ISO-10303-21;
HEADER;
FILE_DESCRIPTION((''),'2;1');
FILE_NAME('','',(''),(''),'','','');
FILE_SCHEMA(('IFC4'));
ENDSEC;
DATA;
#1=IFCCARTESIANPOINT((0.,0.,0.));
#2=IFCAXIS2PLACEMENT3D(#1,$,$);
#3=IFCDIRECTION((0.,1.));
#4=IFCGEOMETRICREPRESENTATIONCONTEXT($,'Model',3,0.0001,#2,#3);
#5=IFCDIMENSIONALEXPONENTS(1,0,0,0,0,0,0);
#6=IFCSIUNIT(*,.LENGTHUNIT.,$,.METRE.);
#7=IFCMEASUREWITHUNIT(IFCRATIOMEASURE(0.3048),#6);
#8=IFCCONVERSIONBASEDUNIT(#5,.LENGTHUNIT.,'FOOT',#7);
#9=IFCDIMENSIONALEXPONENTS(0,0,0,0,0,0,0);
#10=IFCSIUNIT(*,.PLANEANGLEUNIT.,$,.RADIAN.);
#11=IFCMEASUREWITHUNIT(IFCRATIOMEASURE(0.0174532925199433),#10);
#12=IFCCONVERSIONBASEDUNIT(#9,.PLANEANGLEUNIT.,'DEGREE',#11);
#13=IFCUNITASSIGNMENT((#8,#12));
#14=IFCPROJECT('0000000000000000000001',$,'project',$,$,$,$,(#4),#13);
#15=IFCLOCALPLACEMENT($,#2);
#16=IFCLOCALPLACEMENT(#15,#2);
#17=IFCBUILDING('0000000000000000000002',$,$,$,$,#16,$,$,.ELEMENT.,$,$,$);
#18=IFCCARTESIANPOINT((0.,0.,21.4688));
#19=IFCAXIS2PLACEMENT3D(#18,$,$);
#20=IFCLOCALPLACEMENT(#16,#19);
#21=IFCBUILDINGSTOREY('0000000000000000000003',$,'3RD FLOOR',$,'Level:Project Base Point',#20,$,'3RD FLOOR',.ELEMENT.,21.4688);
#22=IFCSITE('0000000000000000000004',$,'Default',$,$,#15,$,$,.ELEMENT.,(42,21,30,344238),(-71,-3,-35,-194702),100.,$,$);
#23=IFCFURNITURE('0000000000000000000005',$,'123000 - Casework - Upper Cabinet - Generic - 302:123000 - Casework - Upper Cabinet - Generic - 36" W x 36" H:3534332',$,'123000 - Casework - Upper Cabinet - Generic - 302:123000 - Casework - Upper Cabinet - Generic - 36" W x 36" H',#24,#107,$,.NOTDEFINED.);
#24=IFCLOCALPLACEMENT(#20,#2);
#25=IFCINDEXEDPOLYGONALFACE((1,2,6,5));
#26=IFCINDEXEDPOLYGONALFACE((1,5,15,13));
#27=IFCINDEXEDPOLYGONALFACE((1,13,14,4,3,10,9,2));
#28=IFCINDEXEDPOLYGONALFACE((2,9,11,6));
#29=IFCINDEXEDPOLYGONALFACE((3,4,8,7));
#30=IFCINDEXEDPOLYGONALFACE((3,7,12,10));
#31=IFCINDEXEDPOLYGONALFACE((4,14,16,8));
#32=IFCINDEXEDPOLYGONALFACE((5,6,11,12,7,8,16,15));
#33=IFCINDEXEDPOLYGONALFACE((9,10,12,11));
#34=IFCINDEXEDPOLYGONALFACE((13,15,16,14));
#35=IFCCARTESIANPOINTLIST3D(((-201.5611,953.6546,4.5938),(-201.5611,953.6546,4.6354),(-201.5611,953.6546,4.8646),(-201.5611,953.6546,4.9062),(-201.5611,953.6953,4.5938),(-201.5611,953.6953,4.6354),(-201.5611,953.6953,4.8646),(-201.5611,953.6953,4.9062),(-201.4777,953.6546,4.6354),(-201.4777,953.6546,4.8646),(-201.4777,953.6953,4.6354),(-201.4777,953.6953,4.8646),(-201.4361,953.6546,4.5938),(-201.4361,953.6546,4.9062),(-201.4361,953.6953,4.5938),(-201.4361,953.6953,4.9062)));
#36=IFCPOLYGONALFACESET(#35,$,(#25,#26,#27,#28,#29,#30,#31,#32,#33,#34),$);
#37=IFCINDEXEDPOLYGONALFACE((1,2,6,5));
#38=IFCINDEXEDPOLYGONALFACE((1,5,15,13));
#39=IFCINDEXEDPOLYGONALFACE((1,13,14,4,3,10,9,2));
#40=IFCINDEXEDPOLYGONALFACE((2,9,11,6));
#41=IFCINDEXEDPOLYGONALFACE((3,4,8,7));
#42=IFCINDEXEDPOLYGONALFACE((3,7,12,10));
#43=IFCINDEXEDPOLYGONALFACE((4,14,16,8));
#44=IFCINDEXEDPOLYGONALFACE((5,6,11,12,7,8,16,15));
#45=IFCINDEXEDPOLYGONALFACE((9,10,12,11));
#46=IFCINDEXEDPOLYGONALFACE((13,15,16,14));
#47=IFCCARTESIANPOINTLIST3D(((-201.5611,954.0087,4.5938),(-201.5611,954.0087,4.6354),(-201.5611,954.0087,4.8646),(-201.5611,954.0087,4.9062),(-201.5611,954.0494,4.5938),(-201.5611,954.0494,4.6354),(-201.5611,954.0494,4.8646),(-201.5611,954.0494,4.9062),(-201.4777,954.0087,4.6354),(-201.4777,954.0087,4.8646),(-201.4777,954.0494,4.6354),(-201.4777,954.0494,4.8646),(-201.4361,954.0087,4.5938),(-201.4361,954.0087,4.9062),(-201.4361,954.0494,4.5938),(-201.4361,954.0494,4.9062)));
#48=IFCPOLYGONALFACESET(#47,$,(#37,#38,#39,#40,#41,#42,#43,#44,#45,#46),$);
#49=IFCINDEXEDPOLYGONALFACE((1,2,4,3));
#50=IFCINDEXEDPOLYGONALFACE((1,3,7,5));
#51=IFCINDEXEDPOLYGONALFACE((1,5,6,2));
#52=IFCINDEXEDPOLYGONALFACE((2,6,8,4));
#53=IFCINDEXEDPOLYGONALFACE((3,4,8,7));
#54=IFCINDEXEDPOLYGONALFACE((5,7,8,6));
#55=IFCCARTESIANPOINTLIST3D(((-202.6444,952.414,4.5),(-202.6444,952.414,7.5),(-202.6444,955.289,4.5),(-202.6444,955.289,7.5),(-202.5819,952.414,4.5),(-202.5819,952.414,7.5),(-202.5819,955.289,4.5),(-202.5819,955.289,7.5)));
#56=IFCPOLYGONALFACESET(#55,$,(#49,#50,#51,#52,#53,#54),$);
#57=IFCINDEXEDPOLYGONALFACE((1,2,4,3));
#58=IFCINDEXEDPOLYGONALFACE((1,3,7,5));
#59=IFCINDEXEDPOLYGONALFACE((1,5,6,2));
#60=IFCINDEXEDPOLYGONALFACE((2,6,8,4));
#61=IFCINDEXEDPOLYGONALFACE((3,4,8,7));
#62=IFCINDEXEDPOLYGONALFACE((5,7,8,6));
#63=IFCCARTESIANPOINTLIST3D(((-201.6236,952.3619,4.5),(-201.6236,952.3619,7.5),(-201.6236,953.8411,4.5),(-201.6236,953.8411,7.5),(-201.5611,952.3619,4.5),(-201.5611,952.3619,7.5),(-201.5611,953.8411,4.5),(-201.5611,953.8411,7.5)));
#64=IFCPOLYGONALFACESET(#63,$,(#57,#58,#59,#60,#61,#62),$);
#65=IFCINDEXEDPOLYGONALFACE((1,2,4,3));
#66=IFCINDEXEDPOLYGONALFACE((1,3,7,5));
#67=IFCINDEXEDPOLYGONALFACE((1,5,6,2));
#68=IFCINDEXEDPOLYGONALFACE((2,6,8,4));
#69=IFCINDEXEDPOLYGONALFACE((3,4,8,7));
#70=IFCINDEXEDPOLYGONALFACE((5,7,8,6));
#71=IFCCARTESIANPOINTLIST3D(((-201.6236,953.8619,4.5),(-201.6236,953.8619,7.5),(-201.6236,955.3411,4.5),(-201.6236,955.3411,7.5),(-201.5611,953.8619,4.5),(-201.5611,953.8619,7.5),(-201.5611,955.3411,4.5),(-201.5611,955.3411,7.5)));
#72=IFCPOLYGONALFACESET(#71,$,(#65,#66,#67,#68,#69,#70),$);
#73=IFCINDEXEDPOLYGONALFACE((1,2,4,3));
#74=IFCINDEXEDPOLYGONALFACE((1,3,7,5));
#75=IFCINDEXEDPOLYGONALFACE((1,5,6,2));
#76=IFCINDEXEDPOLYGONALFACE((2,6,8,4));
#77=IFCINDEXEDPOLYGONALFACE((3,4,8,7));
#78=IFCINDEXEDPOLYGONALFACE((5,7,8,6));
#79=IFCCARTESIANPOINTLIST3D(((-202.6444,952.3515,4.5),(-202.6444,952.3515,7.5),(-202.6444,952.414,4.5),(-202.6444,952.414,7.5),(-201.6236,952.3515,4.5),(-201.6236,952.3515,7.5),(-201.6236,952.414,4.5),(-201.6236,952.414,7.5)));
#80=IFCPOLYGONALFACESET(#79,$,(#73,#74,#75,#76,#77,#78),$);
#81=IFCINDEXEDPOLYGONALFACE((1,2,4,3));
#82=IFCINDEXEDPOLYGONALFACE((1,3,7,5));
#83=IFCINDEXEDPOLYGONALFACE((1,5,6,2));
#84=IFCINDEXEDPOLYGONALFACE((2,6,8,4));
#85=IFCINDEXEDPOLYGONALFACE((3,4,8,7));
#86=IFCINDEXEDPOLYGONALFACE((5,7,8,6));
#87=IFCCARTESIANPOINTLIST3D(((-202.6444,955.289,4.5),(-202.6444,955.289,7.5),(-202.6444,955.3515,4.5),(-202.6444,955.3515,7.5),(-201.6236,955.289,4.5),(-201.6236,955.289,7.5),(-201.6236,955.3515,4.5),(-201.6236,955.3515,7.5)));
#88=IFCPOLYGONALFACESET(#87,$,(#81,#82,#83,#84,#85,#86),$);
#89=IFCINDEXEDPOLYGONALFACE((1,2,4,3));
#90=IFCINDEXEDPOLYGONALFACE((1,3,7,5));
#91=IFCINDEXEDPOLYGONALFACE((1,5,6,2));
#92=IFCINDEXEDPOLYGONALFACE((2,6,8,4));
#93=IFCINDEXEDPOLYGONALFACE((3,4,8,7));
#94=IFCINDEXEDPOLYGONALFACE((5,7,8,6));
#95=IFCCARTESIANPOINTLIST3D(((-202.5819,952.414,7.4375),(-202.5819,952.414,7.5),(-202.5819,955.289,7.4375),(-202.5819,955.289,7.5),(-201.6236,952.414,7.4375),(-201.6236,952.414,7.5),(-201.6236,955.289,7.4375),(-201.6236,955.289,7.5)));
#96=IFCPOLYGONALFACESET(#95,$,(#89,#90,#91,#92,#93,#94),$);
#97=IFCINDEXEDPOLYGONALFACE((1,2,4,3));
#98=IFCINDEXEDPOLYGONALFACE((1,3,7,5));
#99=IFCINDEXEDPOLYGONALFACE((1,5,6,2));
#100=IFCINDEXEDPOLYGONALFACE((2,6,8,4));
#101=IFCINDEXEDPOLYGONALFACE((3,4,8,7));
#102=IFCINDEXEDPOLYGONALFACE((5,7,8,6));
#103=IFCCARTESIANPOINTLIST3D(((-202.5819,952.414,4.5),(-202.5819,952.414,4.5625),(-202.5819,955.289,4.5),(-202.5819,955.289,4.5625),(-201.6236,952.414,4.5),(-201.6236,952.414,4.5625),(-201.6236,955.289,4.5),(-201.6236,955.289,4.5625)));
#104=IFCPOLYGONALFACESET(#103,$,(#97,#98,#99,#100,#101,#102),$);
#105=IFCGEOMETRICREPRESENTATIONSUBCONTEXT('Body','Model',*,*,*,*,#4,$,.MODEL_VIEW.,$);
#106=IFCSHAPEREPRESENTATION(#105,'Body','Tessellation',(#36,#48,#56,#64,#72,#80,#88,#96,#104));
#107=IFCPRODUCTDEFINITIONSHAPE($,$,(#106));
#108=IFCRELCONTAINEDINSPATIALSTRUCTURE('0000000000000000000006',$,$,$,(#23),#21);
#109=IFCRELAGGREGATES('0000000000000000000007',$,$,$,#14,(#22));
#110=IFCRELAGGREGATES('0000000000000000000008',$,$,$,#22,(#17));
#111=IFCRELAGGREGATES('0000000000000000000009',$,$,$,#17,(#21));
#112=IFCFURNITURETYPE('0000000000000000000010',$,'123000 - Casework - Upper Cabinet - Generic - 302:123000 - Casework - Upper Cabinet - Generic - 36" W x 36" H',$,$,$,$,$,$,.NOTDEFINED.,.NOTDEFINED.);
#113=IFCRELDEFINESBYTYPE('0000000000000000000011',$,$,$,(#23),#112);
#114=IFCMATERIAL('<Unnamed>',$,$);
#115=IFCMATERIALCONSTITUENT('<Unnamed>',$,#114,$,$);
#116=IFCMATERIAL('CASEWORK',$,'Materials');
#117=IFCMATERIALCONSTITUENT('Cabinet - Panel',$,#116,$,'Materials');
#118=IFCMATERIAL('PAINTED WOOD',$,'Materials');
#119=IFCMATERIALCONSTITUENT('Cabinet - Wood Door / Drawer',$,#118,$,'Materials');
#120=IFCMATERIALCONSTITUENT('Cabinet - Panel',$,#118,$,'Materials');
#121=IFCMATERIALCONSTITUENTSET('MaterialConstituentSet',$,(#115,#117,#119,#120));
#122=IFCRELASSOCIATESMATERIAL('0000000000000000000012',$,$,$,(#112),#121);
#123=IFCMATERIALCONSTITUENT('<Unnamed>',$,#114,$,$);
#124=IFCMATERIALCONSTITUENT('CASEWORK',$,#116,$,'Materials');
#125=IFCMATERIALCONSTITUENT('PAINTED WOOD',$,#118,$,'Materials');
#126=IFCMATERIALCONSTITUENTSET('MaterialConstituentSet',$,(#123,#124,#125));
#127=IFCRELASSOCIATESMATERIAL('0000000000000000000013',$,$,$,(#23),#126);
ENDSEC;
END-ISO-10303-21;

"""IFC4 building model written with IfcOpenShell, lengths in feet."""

from ifc_helpers import new_model, entity, si_unit, converted_unit, direction, frame, frame_2d, origin, origin_2d_with_axis, place, context, subcontext, project, spatial, polyline, rectangle, outline, extrude, source, transform, mapped, material, constituent, constituent_set, type_object, type_shapes, element, save


model = new_model("IFC4")

# Units and contexts
model_context = context("Model", 3, precision=0.0001, world=origin(), true_north=direction((0.0, 1.0)))
body_context = subcontext(model_context, "Body", "Model", "MODEL_VIEW")
ifc_project = project(units=[converted_unit("LENGTHUNIT", "FOOT", entity("IfcRatioMeasure", 0.3048), si_unit("LENGTHUNIT", "METRE"), dimensions=[1, 0, 0, 0, 0, 0, 0]), converted_unit("PLANEANGLEUNIT", "DEGREE", entity("IfcRatioMeasure", 0.0174532925199433), si_unit("PLANEANGLEUNIT", "RADIAN"), dimensions=[0, 0, 0, 0, 0, 0, 0])], contexts=[model_context])

# Site, building, storey
site_placement = place(None, origin())
site = spatial("IfcSite", under=ifc_project, at=site_placement, Name="Default", CompositionType="ELEMENT", RefLatitude=(42, 21, 30, 344238), RefLongitude=(-71, -3, -35, -194702), RefElevation=100.0)
building_placement = place(site_placement, origin())
building = spatial("IfcBuilding", under=site, at=building_placement, CompositionType="ELEMENT")
storey_placement = place(building_placement, frame((0.0, 0.0, 21.4688)))
storey = spatial("IfcBuildingStorey", under=building, at=storey_placement, Name="3RD FLOOR", ObjectType="Level:Project Base Point", LongName="3RD FLOOR", CompositionType="ELEMENT", Elevation=21.4688)

# Furniture
ifc_material_1 = material(Name="PAINTED WOOD", Category="Materials")
ifc_material_2 = material(Name="CASEWORK", Category="Materials")
ifc_material_3 = material(Name="<Unnamed>")
ifc_constituent_1 = constituent(ifc_material_3, Name="<Unnamed>")
ifc_constituent_2 = constituent(ifc_material_2, Name="CASEWORK", Category="Materials")
ifc_constituent_3 = constituent(ifc_material_1, Name="PAINTED WOOD", Category="Materials")
ifc_constituent_set_1 = constituent_set(constituents=[ifc_constituent_1, ifc_constituent_2, ifc_constituent_3], Name="MaterialConstituentSet")
ifc_constituent_4 = constituent(ifc_material_3, Name="<Unnamed>")
ifc_constituent_5 = constituent(ifc_material_2, Name="Cabinet - Panel", Category="Materials")
ifc_constituent_6 = constituent(ifc_material_1, Name="Cabinet - Wood Door / Drawer", Category="Materials")
ifc_constituent_7 = constituent(ifc_material_1, Name="Cabinet - Panel", Category="Materials")
ifc_constituent_set_2 = constituent_set(constituents=[ifc_constituent_4, ifc_constituent_5, ifc_constituent_6, ifc_constituent_7], Name="MaterialConstituentSet")
furniture_type_1 = type_object("IfcFurnitureType", Name="123000 - Casework - Upper Cabinet - Generic - 302:123000 - Casework - Upper Cabinet - Generic - 36\" W x 36\" H", AssemblyPlace="NOTDEFINED", PredefinedType="NOTDEFINED", material=ifc_constituent_set_2)
shared_shape_1 = source(origin(), body_context, "Body", "SweptSolid", [
    extrude(outline(polyline([(0.1146, -0.0521), (0.1562, -0.0521), (0.1562, 0.0729), (-0.1562, 0.0729), (-0.1562, -0.0521), (-0.1146, -0.0521), (-0.1146, 0.0313), (0.1146, 0.0313), (0.1146, -0.0521)])), frame((1.303, 0.0729, 0.25), z_axis=(1.0, 0.0, 0.0), x_axis=(0.0, 0.0, 1.0)), (0.0, 0.0, 1.0), 0.0407),
    extrude(outline(polyline([(0.1146, -0.0521), (0.1562, -0.0521), (0.1562, 0.0729), (-0.1562, 0.0729), (-0.1562, -0.0521), (-0.1146, -0.0521), (-0.1146, 0.0313), (0.1146, 0.0313), (0.1146, -0.0521)])), frame((1.6572, 0.0729, 0.25), z_axis=(1.0, 0.0, 0.0), x_axis=(0.0, 0.0, 1.0)), (0.0, 0.0, 1.0), 0.0407),
    extrude(rectangle(XDim=0.0625, YDim=2.875, at=origin_2d_with_axis()), frame((1.5, 1.177, 0.0), z_axis=(0.0, 0.0, 1.0), x_axis=(0.0, 1.0, 0.0)), (0.0, 0.0, 1.0), 3.0),
    extrude(rectangle(XDim=0.0625, YDim=1.4792, at=frame_2d((0.0, 0.0), x_axis=(1.0, 0.0))), frame((0.75, 0.1562, 0.0), z_axis=(0.0, 0.0, 1.0), x_axis=(0.0, -1.0, 0.0)), (0.0, 0.0, 1.0), 3.0),
    extrude(rectangle(XDim=0.0625, YDim=1.4792, at=origin_2d_with_axis()), frame((2.25, 0.1562, 0.0), z_axis=(0.0, 0.0, 1.0), x_axis=(0.0, -1.0, 0.0)), (0.0, 0.0, 1.0), 3.0),
    extrude(rectangle(XDim=0.0625, YDim=1.0208, at=origin_2d_with_axis()), frame((0.0312, 0.6979, 0.0), z_axis=(0.0, 0.0, 1.0), x_axis=(-1.0, 0.0, 0.0)), (0.0, 0.0, 1.0), 3.0),
    extrude(rectangle(XDim=0.0625, YDim=1.0208, at=origin_2d_with_axis()), frame((2.9688, 0.6979, 0.0), z_axis=(0.0, 0.0, 1.0), x_axis=(-1.0, 0.0, 0.0)), (0.0, 0.0, 1.0), 3.0),
    extrude(rectangle(XDim=2.875, YDim=0.9583, at=frame_2d((0.0, 0.0), x_axis=(1.0, 0.0))), frame((1.5, 0.6666, 2.9375), z_axis=(0.0, 0.0, 1.0), x_axis=(-1.0, 0.0, 0.0)), (0.0, 0.0, 1.0), 0.0625),
    extrude(rectangle(XDim=2.875, YDim=0.9583, at=frame_2d((0.0, 0.0), x_axis=(1.0, 0.0))), frame((1.5, 0.6666, 0.0), z_axis=(0.0, 0.0, 1.0), x_axis=(-1.0, 0.0, 0.0)), (0.0, 0.0, 1.0), 0.0625),
])
type_shapes(furniture_type_1, [shared_shape_1])
furniture_1_placement = place(storey_placement, frame((-201.4361, 952.3515, 4.5), z_axis=(0.0, 0.0, 1.0), x_axis=(0.0, 1.0, 0.0)))
element("IfcFurniture", 1, at=furniture_1_placement, inside=storey, type_object=furniture_type_1, material=ifc_constituent_set_1, Name="123000 - Casework - Upper Cabinet - Generic - 302:123000 - Casework - Upper Cabinet - Generic - 36\" W x 36\" H:3534332", ObjectType="123000 - Casework - Upper Cabinet - Generic - 302:123000 - Casework - Upper Cabinet - Generic - 36\" W x 36\" H", PredefinedType="NOTDEFINED", context=body_context, shape_type="MappedRepresentation", body=[
    mapped(shared_shape_1, transform((0.0, 0.0, 0.0), scale=1.0)),
])

save(model, "model.ifc")
